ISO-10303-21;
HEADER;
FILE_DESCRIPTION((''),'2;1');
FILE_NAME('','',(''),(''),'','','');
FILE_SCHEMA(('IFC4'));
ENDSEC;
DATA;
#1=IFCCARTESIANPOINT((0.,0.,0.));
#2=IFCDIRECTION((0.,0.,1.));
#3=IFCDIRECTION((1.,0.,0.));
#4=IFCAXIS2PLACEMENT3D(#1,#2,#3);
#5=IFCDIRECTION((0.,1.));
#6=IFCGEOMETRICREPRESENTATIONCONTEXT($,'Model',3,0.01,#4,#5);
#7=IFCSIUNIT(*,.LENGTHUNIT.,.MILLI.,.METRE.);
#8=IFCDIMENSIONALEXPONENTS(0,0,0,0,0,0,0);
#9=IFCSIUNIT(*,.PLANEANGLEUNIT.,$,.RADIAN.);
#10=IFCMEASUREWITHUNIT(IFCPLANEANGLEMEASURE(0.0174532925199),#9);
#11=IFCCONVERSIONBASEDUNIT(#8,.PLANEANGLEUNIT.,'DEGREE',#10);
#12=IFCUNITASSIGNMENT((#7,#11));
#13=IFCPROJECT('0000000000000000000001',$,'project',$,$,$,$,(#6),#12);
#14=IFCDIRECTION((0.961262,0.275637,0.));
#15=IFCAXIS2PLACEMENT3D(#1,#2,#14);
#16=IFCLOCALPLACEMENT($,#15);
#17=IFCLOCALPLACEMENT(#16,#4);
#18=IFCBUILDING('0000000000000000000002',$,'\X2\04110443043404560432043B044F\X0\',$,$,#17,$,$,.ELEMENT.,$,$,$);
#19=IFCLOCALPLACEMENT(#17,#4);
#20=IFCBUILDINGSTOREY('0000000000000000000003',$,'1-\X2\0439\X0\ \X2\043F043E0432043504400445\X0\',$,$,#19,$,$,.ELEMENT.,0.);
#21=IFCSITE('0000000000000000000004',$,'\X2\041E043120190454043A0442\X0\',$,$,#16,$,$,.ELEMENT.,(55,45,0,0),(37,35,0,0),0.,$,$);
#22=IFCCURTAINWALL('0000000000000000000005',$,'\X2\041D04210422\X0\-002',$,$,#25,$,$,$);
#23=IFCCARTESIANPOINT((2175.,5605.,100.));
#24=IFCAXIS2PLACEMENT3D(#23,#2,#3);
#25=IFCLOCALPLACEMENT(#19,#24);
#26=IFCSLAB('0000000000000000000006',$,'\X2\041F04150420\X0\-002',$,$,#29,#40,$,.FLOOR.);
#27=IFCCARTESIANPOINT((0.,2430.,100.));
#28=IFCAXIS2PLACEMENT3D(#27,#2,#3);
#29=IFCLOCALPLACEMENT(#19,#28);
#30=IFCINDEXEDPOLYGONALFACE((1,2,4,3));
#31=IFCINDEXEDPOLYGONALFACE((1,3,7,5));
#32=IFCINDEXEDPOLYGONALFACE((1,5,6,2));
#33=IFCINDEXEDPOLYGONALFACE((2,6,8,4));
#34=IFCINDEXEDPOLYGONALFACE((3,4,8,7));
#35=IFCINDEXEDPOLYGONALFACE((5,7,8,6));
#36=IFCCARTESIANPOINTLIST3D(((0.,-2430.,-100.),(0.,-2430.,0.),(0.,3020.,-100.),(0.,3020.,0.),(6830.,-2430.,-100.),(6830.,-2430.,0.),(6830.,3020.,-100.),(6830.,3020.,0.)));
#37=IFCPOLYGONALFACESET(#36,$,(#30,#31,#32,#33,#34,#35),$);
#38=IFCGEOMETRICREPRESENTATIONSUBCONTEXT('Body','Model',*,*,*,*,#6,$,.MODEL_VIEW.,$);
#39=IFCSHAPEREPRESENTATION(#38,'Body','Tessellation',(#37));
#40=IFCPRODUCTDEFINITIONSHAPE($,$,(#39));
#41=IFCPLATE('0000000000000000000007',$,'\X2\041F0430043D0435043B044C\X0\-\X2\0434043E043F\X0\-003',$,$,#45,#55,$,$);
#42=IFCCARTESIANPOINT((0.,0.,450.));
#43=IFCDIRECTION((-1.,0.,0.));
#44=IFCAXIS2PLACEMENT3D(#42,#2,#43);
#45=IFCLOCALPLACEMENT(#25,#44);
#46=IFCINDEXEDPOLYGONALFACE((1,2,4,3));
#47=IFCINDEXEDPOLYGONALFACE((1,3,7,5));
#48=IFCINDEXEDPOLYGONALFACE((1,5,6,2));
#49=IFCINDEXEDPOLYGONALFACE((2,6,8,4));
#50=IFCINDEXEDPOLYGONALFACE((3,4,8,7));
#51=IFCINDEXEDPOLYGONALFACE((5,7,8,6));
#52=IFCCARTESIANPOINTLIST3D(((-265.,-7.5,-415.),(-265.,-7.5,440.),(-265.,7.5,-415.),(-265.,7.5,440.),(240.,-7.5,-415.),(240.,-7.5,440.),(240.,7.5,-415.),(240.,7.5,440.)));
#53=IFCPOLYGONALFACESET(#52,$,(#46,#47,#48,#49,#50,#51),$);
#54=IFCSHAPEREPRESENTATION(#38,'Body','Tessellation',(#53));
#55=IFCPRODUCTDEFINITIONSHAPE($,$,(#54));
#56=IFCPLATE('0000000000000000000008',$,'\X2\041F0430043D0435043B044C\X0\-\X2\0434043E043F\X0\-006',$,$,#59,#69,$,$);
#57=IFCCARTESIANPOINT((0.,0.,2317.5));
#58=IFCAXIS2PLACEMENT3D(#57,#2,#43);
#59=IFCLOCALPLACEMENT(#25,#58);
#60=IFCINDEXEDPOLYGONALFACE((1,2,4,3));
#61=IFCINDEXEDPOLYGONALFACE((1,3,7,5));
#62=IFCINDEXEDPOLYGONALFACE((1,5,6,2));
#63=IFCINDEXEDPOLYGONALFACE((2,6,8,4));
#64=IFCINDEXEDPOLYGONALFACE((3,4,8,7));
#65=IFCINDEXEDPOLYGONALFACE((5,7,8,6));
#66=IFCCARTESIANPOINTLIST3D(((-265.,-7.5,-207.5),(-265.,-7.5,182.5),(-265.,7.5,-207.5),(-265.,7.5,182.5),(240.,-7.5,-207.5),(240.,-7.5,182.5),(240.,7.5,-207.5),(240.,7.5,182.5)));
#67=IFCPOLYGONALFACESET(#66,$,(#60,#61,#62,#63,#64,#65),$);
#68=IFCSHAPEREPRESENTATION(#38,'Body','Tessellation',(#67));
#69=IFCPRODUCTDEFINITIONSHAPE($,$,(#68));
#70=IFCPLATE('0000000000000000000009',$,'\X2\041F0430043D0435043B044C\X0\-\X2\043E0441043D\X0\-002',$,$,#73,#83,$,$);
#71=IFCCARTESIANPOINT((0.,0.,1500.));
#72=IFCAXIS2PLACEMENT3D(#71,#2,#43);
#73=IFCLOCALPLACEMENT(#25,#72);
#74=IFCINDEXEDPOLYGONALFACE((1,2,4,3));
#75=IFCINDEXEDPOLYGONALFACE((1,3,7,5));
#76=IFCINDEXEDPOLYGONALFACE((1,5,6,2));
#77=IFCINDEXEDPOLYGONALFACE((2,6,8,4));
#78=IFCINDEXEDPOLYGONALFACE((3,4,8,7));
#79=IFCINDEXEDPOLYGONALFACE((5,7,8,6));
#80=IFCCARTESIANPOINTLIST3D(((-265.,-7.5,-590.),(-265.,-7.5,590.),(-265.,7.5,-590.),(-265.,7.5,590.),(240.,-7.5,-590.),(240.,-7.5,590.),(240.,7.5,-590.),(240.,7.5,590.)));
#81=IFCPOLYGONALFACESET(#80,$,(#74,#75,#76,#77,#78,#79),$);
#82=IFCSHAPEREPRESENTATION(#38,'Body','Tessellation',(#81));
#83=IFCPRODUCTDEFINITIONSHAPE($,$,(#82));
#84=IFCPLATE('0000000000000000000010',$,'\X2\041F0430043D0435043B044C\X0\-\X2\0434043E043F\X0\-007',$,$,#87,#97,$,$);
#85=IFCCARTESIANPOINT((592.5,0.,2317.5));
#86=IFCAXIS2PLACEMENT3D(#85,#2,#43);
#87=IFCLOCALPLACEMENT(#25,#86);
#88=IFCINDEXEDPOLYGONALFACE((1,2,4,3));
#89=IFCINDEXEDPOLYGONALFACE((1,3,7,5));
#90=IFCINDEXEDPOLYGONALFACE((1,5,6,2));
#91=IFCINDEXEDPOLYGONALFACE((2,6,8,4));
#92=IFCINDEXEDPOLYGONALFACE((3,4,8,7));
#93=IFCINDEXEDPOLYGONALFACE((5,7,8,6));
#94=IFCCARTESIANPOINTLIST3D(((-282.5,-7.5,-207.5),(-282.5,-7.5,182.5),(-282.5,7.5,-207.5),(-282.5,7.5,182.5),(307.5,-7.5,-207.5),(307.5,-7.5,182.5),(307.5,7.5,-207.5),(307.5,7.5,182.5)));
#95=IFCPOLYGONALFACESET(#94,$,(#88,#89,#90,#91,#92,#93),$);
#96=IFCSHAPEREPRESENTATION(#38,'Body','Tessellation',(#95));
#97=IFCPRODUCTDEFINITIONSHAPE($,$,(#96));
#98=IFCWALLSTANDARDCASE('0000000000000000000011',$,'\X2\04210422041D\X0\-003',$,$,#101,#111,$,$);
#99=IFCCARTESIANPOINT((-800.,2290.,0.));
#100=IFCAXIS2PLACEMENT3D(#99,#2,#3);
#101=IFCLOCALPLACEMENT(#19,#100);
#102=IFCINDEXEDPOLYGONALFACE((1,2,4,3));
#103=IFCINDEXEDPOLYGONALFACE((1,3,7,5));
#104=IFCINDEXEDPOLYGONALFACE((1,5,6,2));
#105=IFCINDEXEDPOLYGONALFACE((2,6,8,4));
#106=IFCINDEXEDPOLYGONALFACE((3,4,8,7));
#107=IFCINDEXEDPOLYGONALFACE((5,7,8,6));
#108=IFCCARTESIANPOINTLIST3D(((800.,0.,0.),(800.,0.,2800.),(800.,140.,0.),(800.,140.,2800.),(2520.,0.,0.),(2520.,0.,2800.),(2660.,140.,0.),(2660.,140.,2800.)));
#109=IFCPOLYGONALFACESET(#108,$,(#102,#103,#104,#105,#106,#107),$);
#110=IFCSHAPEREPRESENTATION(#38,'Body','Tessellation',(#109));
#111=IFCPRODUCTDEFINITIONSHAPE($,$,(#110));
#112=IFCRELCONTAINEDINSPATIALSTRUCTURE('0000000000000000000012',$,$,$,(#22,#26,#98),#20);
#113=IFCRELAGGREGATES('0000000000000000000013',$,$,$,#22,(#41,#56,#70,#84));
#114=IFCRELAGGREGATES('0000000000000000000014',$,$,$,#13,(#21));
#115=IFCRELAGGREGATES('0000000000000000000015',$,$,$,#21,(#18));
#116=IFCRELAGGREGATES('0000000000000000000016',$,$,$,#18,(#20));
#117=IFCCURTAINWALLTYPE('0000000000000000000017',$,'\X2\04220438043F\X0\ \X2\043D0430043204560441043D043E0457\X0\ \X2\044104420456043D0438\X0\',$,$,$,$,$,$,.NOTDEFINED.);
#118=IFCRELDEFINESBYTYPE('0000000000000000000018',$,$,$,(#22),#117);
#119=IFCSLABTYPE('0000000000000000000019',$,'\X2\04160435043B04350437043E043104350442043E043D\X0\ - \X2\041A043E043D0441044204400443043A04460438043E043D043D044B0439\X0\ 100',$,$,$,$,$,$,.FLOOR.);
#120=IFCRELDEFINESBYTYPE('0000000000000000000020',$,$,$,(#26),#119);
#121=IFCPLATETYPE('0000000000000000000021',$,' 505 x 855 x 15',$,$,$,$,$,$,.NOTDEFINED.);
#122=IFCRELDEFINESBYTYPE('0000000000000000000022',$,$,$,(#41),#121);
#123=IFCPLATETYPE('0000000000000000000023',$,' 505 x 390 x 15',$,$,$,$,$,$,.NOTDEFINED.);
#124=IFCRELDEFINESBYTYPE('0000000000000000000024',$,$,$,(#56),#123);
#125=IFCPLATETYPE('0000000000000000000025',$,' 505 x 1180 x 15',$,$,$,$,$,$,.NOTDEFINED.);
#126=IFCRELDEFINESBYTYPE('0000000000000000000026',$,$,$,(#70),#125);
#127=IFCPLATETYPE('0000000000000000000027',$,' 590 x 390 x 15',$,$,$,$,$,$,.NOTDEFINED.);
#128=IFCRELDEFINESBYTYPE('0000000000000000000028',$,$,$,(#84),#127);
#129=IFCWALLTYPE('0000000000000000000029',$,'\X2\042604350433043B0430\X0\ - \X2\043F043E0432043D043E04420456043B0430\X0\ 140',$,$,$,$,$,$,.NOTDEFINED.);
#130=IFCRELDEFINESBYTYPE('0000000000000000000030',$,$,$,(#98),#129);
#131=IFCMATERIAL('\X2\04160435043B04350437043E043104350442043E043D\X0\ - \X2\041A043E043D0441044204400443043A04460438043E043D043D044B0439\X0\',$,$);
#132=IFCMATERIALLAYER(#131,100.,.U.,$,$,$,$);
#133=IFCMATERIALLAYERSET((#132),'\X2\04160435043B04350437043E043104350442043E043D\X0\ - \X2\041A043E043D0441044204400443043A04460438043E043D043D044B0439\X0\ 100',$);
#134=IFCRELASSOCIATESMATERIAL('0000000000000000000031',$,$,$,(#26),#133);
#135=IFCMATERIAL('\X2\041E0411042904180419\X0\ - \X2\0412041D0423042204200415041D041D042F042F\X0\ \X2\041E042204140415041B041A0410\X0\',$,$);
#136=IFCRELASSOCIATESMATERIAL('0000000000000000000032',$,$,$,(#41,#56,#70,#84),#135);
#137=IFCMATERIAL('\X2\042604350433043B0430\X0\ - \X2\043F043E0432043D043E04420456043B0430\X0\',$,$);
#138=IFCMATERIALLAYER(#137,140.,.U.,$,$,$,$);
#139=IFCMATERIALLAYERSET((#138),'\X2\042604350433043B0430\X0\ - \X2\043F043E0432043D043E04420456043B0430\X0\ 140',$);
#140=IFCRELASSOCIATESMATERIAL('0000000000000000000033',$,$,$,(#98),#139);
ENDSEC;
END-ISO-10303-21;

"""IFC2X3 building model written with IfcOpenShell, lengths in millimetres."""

from ifc_helpers import new_model, entity, si_unit, converted_unit, direction, frame, origin_with_axes, place, context, subcontext, project, spatial, polyline, outline, extrude, material, layer, layer_set, layer_usage, type_object, element, aggregate, save


model = new_model("IFC2X3")

# Units and contexts
model_context = context("Model", 3, precision=0.01, world=origin_with_axes(), true_north=direction((0.0, 1.0)))
body_context = subcontext(model_context, "Body", "Model", "MODEL_VIEW")
ifc_project = project(units=[si_unit("LENGTHUNIT", "METRE", prefix="MILLI"), converted_unit("PLANEANGLEUNIT", "DEGREE", entity("IfcPlaneAngleMeasure", 0.0174532925199), si_unit("PLANEANGLEUNIT", "RADIAN"), dimensions=[0, 0, 0, 0, 0, 0, 0])], contexts=[model_context])

# Site, building, storey
site_placement = place(None, frame((0.0, 0.0, 0.0), z_axis=(0.0, 0.0, 1.0), x_axis=(0.961262, 0.275637, 0.0)))
site = spatial("IfcSite", under=ifc_project, at=site_placement, Name="Об’єкт", CompositionType="ELEMENT", RefLatitude=(55, 45, 0, 0), RefLongitude=(37, 35, 0, 0), RefElevation=0.0)
building_placement = place(site_placement, origin_with_axes())
building = spatial("IfcBuilding", under=site, at=building_placement, Name="Будівля", CompositionType="ELEMENT")
storey_placement = place(building_placement, origin_with_axes())
storey = spatial("IfcBuildingStorey", under=building, at=storey_placement, Name="1-й поверх", CompositionType="ELEMENT", Elevation=0.0)

# Curtain wall
curtain_wall_type = type_object("IfcCurtainWallType", Name="Тип навісної стіни", PredefinedType="NOTDEFINED")
curtain_wall_placement = place(storey_placement, frame((2175.0, 5605.0, 100.0), z_axis=(0.0, 0.0, 1.0), x_axis=(1.0, 0.0, 0.0)))
curtain_wall = element("IfcCurtainWall", 1, at=curtain_wall_placement, inside=storey, type_object=curtain_wall_type, Name="НСТ-002")
ifc_material_1 = material(Name="ОБЩИЙ - ВНУТРЕННЯЯ ОТДЕЛКА")

# Slab
ifc_material_2 = material(Name="Железобетон - Конструкционный")
ifc_layer_1 = layer(ifc_material_2, 100.0, ventilated="UNKNOWN")
ifc_layer_set_1 = layer_set([ifc_layer_1], Name="Железобетон - Конструкционный 100")
ifc_layer_usage_1 = layer_usage(ifc_layer_set_1, "AXIS3", "NEGATIVE", 100.0)
slab_type_1 = type_object("IfcSlabType", Name="Железобетон - Конструкционный 100", PredefinedType="FLOOR")
slab_1_placement = place(storey_placement, frame((0.0, 2430.0, 100.0), z_axis=(0.0, 0.0, 1.0), x_axis=(1.0, 0.0, 0.0)))
element("IfcSlab", 2, at=slab_1_placement, inside=storey, type_object=slab_type_1, material=ifc_layer_usage_1, Name="ПЕР-002", PredefinedType="FLOOR", context=body_context, shape_type="SweptSolid", body=[
    extrude(outline(polyline([(0.0, -2430.0), (6830.0, -2430.0), (6830.0, 3020.0), (0.0, 3020.0), (0.0, -2430.0)])), frame((0.0, 0.0, -100.0), z_axis=(0.0, 0.0, 1.0), x_axis=(1.0, 0.0, 0.0)), (0.0, 0.0, 1.0), 100.0),
])

# Plates
plate_type_1 = type_object("IfcPlateType", Name=" 505 x 855 x 15", PredefinedType="NOTDEFINED")
plate_1_placement = place(curtain_wall_placement, frame((0.0, 0.0, 450.0), z_axis=(0.0, 0.0, 1.0), x_axis=(-1.0, 0.0, 0.0)))
plate_1 = element("IfcPlate", 3, at=plate_1_placement, type_object=plate_type_1, material=ifc_material_1, Name="Панель-доп-003", context=body_context, shape_type="SweptSolid", body=[
    extrude(outline(polyline([(-265.0, -440.0), (240.0, -440.0), (240.0, 415.0), (-265.0, 415.0), (-265.0, -440.0)])), frame((0.0, -7.5, 0.0), z_axis=(0.0, 1.0, 0.0), x_axis=(1.0, 0.0, 0.0)), (0.0, 0.0, 1.0), 15.0),
])
plate_type_2 = type_object("IfcPlateType", Name=" 505 x 390 x 15", PredefinedType="NOTDEFINED")
plate_2_placement = place(curtain_wall_placement, frame((0.0, 0.0, 2317.5), z_axis=(0.0, 0.0, 1.0), x_axis=(-1.0, 0.0, 0.0)))
plate_2 = element("IfcPlate", 4, at=plate_2_placement, type_object=plate_type_2, material=ifc_material_1, Name="Панель-доп-006", context=body_context, shape_type="SweptSolid", body=[
    extrude(outline(polyline([(-265.0, -182.5), (240.0, -182.5), (240.0, 207.5), (-265.0, 207.5), (-265.0, -182.5)])), frame((0.0, -7.5, 0.0), z_axis=(0.0, 1.0, 0.0), x_axis=(1.0, 0.0, 0.0)), (0.0, 0.0, 1.0), 15.0),
])
plate_type_3 = type_object("IfcPlateType", Name=" 505 x 1180 x 15", PredefinedType="NOTDEFINED")
plate_3_placement = place(curtain_wall_placement, frame((0.0, 0.0, 1500.0), z_axis=(0.0, 0.0, 1.0), x_axis=(-1.0, 0.0, 0.0)))
plate_3 = element("IfcPlate", 5, at=plate_3_placement, type_object=plate_type_3, material=ifc_material_1, Name="Панель-осн-002", context=body_context, shape_type="SweptSolid", body=[
    extrude(outline(polyline([(-265.0, -590.0), (240.0, -590.0), (240.0, 590.0), (-265.0, 590.0), (-265.0, -590.0)])), frame((0.0, -7.5, 0.0), z_axis=(0.0, 1.0, 0.0), x_axis=(1.0, 0.0, 0.0)), (0.0, 0.0, 1.0), 15.0),
])
plate_type_4 = type_object("IfcPlateType", Name=" 590 x 390 x 15", PredefinedType="NOTDEFINED")
plate_4_placement = place(curtain_wall_placement, frame((592.5, 0.0, 2317.5), z_axis=(0.0, 0.0, 1.0), x_axis=(-1.0, 0.0, 0.0)))
plate_4 = element("IfcPlate", 6, at=plate_4_placement, type_object=plate_type_4, material=ifc_material_1, Name="Панель-доп-007", context=body_context, shape_type="SweptSolid", body=[
    extrude(outline(polyline([(-282.5, -182.5), (307.5, -182.5), (307.5, 207.5), (-282.5, 207.5), (-282.5, -182.5)])), frame((0.0, -7.5, 0.0), z_axis=(0.0, 1.0, 0.0), x_axis=(1.0, 0.0, 0.0)), (0.0, 0.0, 1.0), 15.0),
])
aggregate(curtain_wall, [plate_1, plate_2, plate_3, plate_4])

# Wall
ifc_material_3 = material(Name="Цегла - повнотіла")
ifc_layer_2 = layer(ifc_material_3, 140.0, ventilated="UNKNOWN")
ifc_layer_set_2 = layer_set([ifc_layer_2], Name="Цегла - повнотіла 140")
wall_type_1 = type_object("IfcWallType", Name="Цегла - повнотіла 140", PredefinedType="NOTDEFINED")
ifc_layer_usage_2 = layer_usage(ifc_layer_set_2, "AXIS2", "POSITIVE", 0.0)
wall_1_placement = place(storey_placement, frame((-800.0, 2290.0, 0.0), z_axis=(0.0, 0.0, 1.0), x_axis=(1.0, 0.0, 0.0)))
element("IfcWallStandardCase", 7, at=wall_1_placement, inside=storey, type_object=wall_type_1, material=ifc_layer_usage_2, Name="СТН-003", context=body_context, shape_type="SweptSolid", body=[
    extrude(outline(polyline([(800.0, 0.0), (2520.0, 0.0), (2660.0, 140.0), (800.0, 140.0), (800.0, 0.0)])), origin_with_axes(), (0.0, 0.0, 1.0), 2800.0),
])

save(model, "model.ifc")
